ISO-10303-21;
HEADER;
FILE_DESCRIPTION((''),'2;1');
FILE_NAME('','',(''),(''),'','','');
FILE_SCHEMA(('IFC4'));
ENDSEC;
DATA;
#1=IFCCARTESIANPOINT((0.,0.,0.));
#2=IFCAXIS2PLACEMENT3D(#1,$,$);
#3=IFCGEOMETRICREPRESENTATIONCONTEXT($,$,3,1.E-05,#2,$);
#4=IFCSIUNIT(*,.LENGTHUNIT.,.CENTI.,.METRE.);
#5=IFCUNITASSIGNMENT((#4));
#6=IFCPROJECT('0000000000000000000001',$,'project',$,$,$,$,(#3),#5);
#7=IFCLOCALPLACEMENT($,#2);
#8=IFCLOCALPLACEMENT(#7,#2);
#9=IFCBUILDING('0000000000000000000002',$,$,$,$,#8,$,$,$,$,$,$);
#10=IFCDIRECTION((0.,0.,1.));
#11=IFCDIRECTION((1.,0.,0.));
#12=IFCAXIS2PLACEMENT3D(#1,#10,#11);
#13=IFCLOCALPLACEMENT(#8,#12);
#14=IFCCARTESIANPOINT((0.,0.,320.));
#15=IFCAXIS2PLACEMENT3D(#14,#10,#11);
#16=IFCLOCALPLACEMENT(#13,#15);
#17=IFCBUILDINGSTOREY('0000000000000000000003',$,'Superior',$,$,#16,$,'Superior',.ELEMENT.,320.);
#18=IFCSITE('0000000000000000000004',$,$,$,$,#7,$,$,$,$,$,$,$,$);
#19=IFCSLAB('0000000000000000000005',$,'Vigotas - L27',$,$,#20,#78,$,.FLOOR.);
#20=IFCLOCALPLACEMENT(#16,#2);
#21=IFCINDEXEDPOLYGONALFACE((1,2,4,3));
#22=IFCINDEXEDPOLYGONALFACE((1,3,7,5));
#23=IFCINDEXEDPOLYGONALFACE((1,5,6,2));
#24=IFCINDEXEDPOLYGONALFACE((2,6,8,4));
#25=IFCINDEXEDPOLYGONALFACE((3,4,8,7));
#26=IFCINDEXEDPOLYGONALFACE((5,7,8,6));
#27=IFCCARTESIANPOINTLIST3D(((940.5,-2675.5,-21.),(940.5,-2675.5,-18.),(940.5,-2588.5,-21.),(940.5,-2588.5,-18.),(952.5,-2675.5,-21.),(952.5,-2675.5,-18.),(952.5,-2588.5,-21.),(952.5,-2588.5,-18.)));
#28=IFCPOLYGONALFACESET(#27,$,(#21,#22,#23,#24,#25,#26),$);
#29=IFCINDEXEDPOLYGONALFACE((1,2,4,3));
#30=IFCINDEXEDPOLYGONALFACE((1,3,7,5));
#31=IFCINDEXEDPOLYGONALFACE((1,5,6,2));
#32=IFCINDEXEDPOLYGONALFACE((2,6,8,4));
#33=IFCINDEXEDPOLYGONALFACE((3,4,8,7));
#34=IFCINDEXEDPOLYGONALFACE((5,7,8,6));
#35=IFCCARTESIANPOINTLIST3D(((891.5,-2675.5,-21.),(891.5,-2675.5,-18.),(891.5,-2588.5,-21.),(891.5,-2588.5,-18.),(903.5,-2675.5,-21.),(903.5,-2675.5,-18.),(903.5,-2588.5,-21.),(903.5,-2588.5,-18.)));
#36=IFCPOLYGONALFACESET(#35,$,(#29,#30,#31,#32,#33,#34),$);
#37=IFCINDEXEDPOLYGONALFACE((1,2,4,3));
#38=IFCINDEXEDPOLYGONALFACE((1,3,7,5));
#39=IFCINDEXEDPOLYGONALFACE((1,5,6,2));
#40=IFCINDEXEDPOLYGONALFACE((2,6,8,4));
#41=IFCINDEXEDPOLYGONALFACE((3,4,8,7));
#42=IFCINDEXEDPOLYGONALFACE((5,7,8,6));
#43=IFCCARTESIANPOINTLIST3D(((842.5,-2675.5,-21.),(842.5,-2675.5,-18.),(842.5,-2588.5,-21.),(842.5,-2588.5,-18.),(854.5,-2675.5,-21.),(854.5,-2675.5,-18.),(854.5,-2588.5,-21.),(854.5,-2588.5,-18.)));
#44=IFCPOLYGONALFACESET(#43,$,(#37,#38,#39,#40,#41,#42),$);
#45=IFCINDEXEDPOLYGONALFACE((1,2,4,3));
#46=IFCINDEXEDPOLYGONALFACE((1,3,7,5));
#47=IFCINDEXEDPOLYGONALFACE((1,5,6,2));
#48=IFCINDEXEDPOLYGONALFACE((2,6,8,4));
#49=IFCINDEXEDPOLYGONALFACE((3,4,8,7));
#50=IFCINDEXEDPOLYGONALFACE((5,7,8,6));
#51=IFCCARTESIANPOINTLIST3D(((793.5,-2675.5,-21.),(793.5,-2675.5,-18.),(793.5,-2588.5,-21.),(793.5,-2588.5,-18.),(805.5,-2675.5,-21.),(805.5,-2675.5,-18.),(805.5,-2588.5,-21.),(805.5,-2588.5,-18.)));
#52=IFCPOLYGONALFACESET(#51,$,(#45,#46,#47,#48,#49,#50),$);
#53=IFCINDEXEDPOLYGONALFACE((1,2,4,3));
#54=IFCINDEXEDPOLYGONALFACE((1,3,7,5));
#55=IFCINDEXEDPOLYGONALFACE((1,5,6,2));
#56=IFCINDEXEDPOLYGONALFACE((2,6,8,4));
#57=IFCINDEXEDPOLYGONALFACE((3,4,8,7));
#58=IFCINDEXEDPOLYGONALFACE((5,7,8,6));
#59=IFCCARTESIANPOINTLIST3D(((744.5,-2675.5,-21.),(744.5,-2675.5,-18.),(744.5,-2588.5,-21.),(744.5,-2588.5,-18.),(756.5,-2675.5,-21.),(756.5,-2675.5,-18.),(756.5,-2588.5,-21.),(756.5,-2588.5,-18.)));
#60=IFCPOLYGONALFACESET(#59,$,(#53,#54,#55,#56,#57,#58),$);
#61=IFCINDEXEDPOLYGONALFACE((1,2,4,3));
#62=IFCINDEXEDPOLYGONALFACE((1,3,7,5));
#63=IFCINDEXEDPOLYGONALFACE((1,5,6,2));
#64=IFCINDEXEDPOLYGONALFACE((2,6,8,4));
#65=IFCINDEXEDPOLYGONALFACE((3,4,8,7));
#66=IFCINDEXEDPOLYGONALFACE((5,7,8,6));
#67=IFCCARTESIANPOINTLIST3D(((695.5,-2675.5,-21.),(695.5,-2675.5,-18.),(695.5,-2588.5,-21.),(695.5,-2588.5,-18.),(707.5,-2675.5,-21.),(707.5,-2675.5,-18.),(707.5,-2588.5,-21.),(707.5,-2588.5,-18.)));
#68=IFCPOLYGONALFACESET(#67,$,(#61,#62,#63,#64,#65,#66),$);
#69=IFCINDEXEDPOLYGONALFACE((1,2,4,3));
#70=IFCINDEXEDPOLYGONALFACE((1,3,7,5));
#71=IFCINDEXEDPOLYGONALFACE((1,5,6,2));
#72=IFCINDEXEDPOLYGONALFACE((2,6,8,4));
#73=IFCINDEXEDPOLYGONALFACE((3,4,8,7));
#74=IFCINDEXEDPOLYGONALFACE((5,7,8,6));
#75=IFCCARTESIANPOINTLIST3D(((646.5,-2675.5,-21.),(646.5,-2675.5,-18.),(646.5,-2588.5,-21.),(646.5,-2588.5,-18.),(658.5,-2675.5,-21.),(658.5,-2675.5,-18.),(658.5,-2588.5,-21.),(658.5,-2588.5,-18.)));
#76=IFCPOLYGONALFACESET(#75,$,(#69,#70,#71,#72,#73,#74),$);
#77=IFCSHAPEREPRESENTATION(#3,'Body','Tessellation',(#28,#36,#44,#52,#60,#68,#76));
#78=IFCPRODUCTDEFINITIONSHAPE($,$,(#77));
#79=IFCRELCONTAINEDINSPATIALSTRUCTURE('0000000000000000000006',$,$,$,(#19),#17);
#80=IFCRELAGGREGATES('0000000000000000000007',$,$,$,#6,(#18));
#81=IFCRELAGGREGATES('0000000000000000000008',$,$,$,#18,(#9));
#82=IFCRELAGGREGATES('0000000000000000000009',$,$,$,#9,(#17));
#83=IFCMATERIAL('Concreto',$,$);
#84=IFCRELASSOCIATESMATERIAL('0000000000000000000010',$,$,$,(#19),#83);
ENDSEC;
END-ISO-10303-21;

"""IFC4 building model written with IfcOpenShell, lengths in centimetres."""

from ifc_helpers import new_model, si_unit, frame, origin, origin_with_axes, place, context, project, spatial, polyline, outline, extrude, material, element, save


model = new_model("IFC4")

# Units and contexts
context_of_model = context(None, 3, precision=1e-05, world=origin())
ifc_project = project(units=[si_unit("LENGTHUNIT", "METRE", prefix="CENTI")], contexts=[context_of_model])

# Site, building, storey
site_placement = place(None, origin())
site = spatial("IfcSite", under=ifc_project, at=site_placement)
building_placement = place(site_placement, origin())
building = spatial("IfcBuilding", under=site, at=building_placement)
placement = place(building_placement, origin_with_axes())
storey_placement = place(placement, frame((0.0, 0.0, 320.0), z_axis=(0.0, 0.0, 1.0), x_axis=(1.0, 0.0, 0.0)))
storey = spatial("IfcBuildingStorey", under=building, at=storey_placement, Name="Superior", LongName="Superior", CompositionType="ELEMENT", Elevation=320.0)

# Shared definitions
ifc_material = material(Name="Concreto")

# Slab
slab_1_placement = place(storey_placement, frame((799.5, -2632.0, -18.0), z_axis=(0.0, 0.0, 1.0), x_axis=(1.0, 0.0, 0.0)))
element("IfcSlab", 1, at=slab_1_placement, inside=storey, material=ifc_material, Name="Vigotas - L27", PredefinedType="FLOOR", context=context_of_model, shape_type="SolidModel", body=[
    extrude(outline(polyline([(6.0, 1.5), (-6.0, 1.5), (-6.0, -1.5), (6.0, -1.5), (6.0, 1.5), (6.0, 1.5)])), frame((147.0, -43.5, -1.5), z_axis=(0.0, 1.0, 0.0), x_axis=(1.0, 0.0, 0.0)), (0.0, 0.0, 1.0), 87.0),
    extrude(outline(polyline([(6.0, 1.5), (-6.0, 1.5), (-6.0, -1.5), (6.0, -1.5), (6.0, 1.5), (6.0, 1.5)])), frame((98.0, -43.5, -1.5), z_axis=(0.0, 1.0, 0.0), x_axis=(1.0, 0.0, 0.0)), (0.0, 0.0, 1.0), 87.0),
    extrude(outline(polyline([(6.0, 1.5), (-6.0, 1.5), (-6.0, -1.5), (6.0, -1.5), (6.0, 1.5), (6.0, 1.5)])), frame((49.0, -43.5, -1.5), z_axis=(0.0, 1.0, 0.0), x_axis=(1.0, 0.0, 0.0)), (0.0, 0.0, 1.0), 87.0),
    extrude(outline(polyline([(6.0, 1.5), (-6.0, 1.5), (-6.0, -1.5), (6.0, -1.5), (6.0, 1.5), (6.0, 1.5)])), frame((0.0, -43.5, -1.5), z_axis=(0.0, 1.0, 0.0), x_axis=(1.0, 0.0, 0.0)), (0.0, 0.0, 1.0), 87.0),
    extrude(outline(polyline([(6.0, 1.5), (-6.0, 1.5), (-6.0, -1.5), (6.0, -1.5), (6.0, 1.5), (6.0, 1.5)])), frame((-49.0, -43.5, -1.5), z_axis=(0.0, 1.0, 0.0), x_axis=(1.0, 0.0, 0.0)), (0.0, 0.0, 1.0), 87.0),
    extrude(outline(polyline([(6.0, 1.5), (-6.0, 1.5), (-6.0, -1.5), (6.0, -1.5), (6.0, 1.5), (6.0, 1.5)])), frame((-98.0, -43.5, -1.5), z_axis=(0.0, 1.0, 0.0), x_axis=(1.0, 0.0, 0.0)), (0.0, 0.0, 1.0), 87.0),
    extrude(outline(polyline([(6.0, 1.5), (-6.0, 1.5), (-6.0, -1.5), (6.0, -1.5), (6.0, 1.5), (6.0, 1.5)])), frame((-147.0, -43.5, -1.5), z_axis=(0.0, 1.0, 0.0), x_axis=(1.0, 0.0, 0.0)), (0.0, 0.0, 1.0), 87.0),
])

save(model, "model.ifc")
